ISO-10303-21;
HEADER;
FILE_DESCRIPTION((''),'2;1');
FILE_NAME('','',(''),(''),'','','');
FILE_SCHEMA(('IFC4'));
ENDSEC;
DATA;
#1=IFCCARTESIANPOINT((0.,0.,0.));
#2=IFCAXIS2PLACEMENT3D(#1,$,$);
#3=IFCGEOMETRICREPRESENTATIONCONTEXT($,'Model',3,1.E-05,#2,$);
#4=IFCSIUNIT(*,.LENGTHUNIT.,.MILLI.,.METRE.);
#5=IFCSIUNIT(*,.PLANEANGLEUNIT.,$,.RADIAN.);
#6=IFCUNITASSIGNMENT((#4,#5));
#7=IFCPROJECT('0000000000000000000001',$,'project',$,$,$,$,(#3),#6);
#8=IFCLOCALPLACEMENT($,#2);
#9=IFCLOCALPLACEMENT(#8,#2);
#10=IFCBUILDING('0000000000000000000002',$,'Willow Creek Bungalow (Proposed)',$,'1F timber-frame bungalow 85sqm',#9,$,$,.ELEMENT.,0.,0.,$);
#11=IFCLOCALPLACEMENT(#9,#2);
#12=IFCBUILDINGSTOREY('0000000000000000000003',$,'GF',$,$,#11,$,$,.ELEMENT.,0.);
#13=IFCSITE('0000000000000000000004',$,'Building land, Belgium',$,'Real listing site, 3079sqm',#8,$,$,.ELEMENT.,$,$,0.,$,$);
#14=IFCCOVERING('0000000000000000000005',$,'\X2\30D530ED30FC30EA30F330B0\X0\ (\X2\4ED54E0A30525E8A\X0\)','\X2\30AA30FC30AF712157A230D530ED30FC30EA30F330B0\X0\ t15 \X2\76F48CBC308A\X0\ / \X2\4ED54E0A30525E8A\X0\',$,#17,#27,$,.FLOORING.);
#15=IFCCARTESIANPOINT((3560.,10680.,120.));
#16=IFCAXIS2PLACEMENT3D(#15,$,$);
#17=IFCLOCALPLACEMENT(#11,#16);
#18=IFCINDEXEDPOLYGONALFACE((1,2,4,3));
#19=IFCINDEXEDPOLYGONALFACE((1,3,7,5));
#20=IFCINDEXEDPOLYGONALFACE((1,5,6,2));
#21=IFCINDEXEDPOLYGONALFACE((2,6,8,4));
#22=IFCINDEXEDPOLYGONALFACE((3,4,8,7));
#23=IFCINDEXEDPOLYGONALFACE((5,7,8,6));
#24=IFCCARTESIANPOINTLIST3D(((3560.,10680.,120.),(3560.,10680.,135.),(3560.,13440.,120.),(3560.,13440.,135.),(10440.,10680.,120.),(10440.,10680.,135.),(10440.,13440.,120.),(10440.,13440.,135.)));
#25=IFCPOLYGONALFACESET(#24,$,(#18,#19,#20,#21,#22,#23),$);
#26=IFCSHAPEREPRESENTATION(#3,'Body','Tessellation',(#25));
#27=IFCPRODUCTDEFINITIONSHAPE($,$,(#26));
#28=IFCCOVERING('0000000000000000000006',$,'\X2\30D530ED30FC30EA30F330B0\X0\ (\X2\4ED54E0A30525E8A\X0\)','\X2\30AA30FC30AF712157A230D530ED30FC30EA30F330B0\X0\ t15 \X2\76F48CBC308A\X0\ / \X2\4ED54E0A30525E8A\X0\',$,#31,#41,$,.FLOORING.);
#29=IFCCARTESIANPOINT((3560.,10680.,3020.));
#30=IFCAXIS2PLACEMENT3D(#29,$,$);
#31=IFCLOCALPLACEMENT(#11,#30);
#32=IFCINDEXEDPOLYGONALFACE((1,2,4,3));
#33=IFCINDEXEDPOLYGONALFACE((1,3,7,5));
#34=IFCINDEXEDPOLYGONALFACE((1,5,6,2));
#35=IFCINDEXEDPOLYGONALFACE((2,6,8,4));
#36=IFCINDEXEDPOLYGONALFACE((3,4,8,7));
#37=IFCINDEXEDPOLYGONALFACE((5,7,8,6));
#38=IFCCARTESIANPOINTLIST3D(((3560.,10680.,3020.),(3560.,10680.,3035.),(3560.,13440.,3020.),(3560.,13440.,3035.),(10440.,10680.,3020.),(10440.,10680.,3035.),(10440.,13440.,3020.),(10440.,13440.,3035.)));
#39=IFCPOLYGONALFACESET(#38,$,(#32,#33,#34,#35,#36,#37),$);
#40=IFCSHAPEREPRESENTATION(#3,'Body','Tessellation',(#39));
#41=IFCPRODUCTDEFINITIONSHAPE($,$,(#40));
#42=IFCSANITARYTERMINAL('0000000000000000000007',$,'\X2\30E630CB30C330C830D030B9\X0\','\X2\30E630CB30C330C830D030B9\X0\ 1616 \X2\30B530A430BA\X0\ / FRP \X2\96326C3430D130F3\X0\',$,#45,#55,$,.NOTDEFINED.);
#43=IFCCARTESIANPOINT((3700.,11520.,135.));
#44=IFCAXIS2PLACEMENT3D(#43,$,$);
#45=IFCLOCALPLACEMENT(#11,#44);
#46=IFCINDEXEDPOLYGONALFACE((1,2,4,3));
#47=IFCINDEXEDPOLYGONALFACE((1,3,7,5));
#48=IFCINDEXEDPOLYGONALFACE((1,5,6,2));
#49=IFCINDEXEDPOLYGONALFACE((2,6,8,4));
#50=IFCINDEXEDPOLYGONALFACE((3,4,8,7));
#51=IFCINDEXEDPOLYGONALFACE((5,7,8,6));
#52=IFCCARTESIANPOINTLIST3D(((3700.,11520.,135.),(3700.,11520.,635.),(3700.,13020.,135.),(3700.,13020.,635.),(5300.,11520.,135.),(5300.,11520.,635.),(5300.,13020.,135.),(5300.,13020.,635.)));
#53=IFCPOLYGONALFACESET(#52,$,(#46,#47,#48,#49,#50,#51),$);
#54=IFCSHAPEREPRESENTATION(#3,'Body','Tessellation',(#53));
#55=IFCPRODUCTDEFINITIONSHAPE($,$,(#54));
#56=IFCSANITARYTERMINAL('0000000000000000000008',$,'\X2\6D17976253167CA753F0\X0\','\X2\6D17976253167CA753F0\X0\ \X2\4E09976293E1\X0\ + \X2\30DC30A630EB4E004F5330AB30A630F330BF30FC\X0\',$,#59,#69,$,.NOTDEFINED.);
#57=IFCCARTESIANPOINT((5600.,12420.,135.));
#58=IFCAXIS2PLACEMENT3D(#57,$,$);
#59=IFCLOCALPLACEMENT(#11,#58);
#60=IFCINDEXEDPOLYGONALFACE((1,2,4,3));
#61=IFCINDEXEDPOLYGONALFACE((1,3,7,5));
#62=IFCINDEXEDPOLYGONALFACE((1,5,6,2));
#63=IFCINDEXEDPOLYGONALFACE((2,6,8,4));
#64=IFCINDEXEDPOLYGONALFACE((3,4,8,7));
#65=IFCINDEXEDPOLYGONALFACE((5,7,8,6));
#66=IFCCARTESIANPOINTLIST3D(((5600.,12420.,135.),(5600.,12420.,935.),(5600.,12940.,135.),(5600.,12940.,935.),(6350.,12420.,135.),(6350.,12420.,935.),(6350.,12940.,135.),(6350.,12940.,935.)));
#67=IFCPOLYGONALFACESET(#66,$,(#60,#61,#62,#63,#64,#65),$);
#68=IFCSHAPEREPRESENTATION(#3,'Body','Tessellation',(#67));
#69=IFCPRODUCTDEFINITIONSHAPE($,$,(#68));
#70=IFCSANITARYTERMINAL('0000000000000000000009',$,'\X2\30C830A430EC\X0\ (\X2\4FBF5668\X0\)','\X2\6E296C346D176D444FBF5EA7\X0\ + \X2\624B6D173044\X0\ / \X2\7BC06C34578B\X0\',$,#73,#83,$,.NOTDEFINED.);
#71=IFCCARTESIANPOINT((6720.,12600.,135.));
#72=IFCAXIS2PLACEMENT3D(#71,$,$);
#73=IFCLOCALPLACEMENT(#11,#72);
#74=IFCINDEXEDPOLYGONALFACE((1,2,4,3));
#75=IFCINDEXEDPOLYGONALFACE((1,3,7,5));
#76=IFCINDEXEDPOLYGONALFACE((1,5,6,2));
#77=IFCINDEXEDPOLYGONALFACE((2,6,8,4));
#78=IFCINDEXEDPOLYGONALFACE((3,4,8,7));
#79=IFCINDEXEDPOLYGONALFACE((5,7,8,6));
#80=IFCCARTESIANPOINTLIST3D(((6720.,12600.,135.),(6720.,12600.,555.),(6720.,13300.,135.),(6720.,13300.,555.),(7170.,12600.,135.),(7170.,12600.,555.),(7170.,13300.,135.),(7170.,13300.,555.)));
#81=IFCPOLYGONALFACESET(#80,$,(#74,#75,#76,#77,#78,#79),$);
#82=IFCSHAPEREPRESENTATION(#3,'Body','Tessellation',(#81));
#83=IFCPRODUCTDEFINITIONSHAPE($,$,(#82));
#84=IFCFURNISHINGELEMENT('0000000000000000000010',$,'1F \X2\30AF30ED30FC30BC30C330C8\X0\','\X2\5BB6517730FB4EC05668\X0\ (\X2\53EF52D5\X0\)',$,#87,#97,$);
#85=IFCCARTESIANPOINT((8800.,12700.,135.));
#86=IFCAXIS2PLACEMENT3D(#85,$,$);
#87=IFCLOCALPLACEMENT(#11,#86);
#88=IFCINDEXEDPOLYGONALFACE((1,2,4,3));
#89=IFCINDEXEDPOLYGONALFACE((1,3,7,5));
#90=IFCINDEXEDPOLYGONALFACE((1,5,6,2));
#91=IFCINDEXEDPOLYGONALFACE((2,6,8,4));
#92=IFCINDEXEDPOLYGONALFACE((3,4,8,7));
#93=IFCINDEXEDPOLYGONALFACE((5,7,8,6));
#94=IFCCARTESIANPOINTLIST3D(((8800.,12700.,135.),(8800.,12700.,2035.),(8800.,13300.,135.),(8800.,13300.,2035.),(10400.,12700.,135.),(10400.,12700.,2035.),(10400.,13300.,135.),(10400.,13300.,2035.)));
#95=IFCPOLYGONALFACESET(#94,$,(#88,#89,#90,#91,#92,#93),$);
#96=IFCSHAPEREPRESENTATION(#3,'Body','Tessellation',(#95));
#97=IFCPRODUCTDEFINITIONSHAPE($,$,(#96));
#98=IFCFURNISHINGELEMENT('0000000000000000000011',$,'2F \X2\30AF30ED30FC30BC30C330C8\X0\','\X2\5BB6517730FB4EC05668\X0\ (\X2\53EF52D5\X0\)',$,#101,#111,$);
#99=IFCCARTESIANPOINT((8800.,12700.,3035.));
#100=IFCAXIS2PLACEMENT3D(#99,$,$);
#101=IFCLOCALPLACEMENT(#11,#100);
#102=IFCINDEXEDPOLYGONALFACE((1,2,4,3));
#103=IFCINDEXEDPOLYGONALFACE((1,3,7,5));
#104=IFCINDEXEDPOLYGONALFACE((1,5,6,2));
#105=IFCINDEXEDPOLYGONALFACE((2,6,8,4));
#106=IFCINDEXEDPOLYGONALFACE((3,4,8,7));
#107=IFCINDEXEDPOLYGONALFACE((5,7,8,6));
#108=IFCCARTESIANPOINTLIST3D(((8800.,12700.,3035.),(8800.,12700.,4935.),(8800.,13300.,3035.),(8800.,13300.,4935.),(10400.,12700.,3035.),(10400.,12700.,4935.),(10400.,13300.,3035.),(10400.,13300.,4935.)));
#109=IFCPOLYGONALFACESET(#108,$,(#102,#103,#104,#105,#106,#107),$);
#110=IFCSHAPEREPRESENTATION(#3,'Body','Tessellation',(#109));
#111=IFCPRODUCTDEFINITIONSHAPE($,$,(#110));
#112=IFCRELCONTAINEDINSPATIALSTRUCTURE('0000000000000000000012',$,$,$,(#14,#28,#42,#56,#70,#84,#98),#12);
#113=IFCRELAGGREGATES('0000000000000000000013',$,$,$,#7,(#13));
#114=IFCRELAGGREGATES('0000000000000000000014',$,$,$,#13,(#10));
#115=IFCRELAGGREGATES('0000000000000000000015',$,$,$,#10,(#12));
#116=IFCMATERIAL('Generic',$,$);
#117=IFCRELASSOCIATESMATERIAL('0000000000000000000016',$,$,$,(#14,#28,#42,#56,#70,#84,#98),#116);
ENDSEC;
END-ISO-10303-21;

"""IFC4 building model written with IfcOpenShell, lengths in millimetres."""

from ifc_helpers import new_model, si_unit, frame, frame_2d, origin, place, context, project, spatial, rectangle, extrude, material, element, save


model = new_model("IFC4")

# Units and contexts
model_context = context("Model", 3, precision=1e-05, world=origin())
ifc_project = project(units=[si_unit("LENGTHUNIT", "METRE", prefix="MILLI"), si_unit("PLANEANGLEUNIT", "RADIAN")], contexts=[model_context])

# Site, building, storey
site_placement = place(None, origin())
site = spatial("IfcSite", under=ifc_project, at=site_placement, Name="Building land, Belgium", ObjectType="Real listing site, 3079sqm", CompositionType="ELEMENT", RefElevation=0.0)
building_placement = place(site_placement, origin())
building = spatial("IfcBuilding", under=site, at=building_placement, Name="Willow Creek Bungalow (Proposed)", ObjectType="1F timber-frame bungalow 85sqm", CompositionType="ELEMENT", ElevationOfRefHeight=0.0, ElevationOfTerrain=0.0)
storey_placement = place(building_placement, origin())
storey = spatial("IfcBuildingStorey", under=building, at=storey_placement, Name="GF", CompositionType="ELEMENT", Elevation=0.0)

# Coverings
ifc_material_1 = material(Name="Generic")
covering_1_placement = place(storey_placement, frame((3560.0, 10680.0, 120.0)))
element("IfcCovering", 1, at=covering_1_placement, inside=storey, material=ifc_material_1, Name="フローリング (仕上げ床)", Description="オーク無垢フローリング t15 直貼り / 仕上げ床", PredefinedType="FLOORING", context=model_context, shape_type="SweptSolid", body=[
    extrude(rectangle(XDim=6880.0, YDim=2760.0, at=frame_2d((3440.0, 1380.0))), frame((3560.0, 10680.0, 120.0)), (0.0, 0.0, 1.0), 15.0),
])
covering_2_placement = place(storey_placement, frame((3560.0, 10680.0, 3020.0)))
element("IfcCovering", 2, at=covering_2_placement, inside=storey, material=ifc_material_1, Name="フローリング (仕上げ床)", Description="オーク無垢フローリング t15 直貼り / 仕上げ床", PredefinedType="FLOORING", context=model_context, shape_type="SweptSolid", body=[
    extrude(rectangle(XDim=6880.0, YDim=2760.0, at=frame_2d((3440.0, 1380.0))), frame((3560.0, 10680.0, 3020.0)), (0.0, 0.0, 1.0), 15.0),
])

# Sanitary terminals
sanitary_terminal_1_placement = place(storey_placement, frame((3700.0, 11520.0, 135.0)))
element("IfcSanitaryTerminal", 3, at=sanitary_terminal_1_placement, inside=storey, material=ifc_material_1, Name="ユニットバス", Description="ユニットバス 1616 サイズ / FRP 防水パン", PredefinedType="NOTDEFINED", context=model_context, shape_type="SweptSolid", body=[
    extrude(rectangle(XDim=1600.0, YDim=1500.0, at=frame_2d((800.0, 750.0))), frame((3700.0, 11520.0, 135.0)), (0.0, 0.0, 1.0), 500.0),
])
sanitary_terminal_2_placement = place(storey_placement, frame((5600.0, 12420.0, 135.0)))
element("IfcSanitaryTerminal", 4, at=sanitary_terminal_2_placement, inside=storey, material=ifc_material_1, Name="洗面化粧台", Description="洗面化粧台 三面鏡 + ボウル一体カウンター", PredefinedType="NOTDEFINED", context=model_context, shape_type="SweptSolid", body=[
    extrude(rectangle(XDim=750.0, YDim=520.0, at=frame_2d((375.0, 260.0))), frame((5600.0, 12420.0, 135.0)), (0.0, 0.0, 1.0), 800.0),
])
sanitary_terminal_3_placement = place(storey_placement, frame((6720.0, 12600.0, 135.0)))
element("IfcSanitaryTerminal", 5, at=sanitary_terminal_3_placement, inside=storey, material=ifc_material_1, Name="トイレ (便器)", Description="温水洗浄便座 + 手洗い / 節水型", PredefinedType="NOTDEFINED", context=model_context, shape_type="SweptSolid", body=[
    extrude(rectangle(XDim=450.0, YDim=700.0, at=frame_2d((225.0, 350.0))), frame((6720.0, 12600.0, 135.0)), (0.0, 0.0, 1.0), 420.0),
])

# Furnishing elements
furnishing_1_placement = place(storey_placement, frame((8800.0, 12700.0, 135.0)))
element("IfcFurnishingElement", 6, at=furnishing_1_placement, inside=storey, material=ifc_material_1, Name="1F クローゼット", Description="家具・什器 (可動)", context=model_context, shape_type="SweptSolid", body=[
    extrude(rectangle(XDim=1600.0, YDim=600.0, at=frame_2d((800.0, 300.0))), frame((8800.0, 12700.0, 135.0)), (0.0, 0.0, 1.0), 1900.0),
])
furnishing_2_placement = place(storey_placement, frame((8800.0, 12700.0, 3035.0)))
element("IfcFurnishingElement", 7, at=furnishing_2_placement, inside=storey, material=ifc_material_1, Name="2F クローゼット", Description="家具・什器 (可動)", context=model_context, shape_type="SweptSolid", body=[
    extrude(rectangle(XDim=1600.0, YDim=600.0, at=frame_2d((800.0, 300.0))), frame((8800.0, 12700.0, 3035.0)), (0.0, 0.0, 1.0), 1900.0),
])

save(model, "model.ifc")
